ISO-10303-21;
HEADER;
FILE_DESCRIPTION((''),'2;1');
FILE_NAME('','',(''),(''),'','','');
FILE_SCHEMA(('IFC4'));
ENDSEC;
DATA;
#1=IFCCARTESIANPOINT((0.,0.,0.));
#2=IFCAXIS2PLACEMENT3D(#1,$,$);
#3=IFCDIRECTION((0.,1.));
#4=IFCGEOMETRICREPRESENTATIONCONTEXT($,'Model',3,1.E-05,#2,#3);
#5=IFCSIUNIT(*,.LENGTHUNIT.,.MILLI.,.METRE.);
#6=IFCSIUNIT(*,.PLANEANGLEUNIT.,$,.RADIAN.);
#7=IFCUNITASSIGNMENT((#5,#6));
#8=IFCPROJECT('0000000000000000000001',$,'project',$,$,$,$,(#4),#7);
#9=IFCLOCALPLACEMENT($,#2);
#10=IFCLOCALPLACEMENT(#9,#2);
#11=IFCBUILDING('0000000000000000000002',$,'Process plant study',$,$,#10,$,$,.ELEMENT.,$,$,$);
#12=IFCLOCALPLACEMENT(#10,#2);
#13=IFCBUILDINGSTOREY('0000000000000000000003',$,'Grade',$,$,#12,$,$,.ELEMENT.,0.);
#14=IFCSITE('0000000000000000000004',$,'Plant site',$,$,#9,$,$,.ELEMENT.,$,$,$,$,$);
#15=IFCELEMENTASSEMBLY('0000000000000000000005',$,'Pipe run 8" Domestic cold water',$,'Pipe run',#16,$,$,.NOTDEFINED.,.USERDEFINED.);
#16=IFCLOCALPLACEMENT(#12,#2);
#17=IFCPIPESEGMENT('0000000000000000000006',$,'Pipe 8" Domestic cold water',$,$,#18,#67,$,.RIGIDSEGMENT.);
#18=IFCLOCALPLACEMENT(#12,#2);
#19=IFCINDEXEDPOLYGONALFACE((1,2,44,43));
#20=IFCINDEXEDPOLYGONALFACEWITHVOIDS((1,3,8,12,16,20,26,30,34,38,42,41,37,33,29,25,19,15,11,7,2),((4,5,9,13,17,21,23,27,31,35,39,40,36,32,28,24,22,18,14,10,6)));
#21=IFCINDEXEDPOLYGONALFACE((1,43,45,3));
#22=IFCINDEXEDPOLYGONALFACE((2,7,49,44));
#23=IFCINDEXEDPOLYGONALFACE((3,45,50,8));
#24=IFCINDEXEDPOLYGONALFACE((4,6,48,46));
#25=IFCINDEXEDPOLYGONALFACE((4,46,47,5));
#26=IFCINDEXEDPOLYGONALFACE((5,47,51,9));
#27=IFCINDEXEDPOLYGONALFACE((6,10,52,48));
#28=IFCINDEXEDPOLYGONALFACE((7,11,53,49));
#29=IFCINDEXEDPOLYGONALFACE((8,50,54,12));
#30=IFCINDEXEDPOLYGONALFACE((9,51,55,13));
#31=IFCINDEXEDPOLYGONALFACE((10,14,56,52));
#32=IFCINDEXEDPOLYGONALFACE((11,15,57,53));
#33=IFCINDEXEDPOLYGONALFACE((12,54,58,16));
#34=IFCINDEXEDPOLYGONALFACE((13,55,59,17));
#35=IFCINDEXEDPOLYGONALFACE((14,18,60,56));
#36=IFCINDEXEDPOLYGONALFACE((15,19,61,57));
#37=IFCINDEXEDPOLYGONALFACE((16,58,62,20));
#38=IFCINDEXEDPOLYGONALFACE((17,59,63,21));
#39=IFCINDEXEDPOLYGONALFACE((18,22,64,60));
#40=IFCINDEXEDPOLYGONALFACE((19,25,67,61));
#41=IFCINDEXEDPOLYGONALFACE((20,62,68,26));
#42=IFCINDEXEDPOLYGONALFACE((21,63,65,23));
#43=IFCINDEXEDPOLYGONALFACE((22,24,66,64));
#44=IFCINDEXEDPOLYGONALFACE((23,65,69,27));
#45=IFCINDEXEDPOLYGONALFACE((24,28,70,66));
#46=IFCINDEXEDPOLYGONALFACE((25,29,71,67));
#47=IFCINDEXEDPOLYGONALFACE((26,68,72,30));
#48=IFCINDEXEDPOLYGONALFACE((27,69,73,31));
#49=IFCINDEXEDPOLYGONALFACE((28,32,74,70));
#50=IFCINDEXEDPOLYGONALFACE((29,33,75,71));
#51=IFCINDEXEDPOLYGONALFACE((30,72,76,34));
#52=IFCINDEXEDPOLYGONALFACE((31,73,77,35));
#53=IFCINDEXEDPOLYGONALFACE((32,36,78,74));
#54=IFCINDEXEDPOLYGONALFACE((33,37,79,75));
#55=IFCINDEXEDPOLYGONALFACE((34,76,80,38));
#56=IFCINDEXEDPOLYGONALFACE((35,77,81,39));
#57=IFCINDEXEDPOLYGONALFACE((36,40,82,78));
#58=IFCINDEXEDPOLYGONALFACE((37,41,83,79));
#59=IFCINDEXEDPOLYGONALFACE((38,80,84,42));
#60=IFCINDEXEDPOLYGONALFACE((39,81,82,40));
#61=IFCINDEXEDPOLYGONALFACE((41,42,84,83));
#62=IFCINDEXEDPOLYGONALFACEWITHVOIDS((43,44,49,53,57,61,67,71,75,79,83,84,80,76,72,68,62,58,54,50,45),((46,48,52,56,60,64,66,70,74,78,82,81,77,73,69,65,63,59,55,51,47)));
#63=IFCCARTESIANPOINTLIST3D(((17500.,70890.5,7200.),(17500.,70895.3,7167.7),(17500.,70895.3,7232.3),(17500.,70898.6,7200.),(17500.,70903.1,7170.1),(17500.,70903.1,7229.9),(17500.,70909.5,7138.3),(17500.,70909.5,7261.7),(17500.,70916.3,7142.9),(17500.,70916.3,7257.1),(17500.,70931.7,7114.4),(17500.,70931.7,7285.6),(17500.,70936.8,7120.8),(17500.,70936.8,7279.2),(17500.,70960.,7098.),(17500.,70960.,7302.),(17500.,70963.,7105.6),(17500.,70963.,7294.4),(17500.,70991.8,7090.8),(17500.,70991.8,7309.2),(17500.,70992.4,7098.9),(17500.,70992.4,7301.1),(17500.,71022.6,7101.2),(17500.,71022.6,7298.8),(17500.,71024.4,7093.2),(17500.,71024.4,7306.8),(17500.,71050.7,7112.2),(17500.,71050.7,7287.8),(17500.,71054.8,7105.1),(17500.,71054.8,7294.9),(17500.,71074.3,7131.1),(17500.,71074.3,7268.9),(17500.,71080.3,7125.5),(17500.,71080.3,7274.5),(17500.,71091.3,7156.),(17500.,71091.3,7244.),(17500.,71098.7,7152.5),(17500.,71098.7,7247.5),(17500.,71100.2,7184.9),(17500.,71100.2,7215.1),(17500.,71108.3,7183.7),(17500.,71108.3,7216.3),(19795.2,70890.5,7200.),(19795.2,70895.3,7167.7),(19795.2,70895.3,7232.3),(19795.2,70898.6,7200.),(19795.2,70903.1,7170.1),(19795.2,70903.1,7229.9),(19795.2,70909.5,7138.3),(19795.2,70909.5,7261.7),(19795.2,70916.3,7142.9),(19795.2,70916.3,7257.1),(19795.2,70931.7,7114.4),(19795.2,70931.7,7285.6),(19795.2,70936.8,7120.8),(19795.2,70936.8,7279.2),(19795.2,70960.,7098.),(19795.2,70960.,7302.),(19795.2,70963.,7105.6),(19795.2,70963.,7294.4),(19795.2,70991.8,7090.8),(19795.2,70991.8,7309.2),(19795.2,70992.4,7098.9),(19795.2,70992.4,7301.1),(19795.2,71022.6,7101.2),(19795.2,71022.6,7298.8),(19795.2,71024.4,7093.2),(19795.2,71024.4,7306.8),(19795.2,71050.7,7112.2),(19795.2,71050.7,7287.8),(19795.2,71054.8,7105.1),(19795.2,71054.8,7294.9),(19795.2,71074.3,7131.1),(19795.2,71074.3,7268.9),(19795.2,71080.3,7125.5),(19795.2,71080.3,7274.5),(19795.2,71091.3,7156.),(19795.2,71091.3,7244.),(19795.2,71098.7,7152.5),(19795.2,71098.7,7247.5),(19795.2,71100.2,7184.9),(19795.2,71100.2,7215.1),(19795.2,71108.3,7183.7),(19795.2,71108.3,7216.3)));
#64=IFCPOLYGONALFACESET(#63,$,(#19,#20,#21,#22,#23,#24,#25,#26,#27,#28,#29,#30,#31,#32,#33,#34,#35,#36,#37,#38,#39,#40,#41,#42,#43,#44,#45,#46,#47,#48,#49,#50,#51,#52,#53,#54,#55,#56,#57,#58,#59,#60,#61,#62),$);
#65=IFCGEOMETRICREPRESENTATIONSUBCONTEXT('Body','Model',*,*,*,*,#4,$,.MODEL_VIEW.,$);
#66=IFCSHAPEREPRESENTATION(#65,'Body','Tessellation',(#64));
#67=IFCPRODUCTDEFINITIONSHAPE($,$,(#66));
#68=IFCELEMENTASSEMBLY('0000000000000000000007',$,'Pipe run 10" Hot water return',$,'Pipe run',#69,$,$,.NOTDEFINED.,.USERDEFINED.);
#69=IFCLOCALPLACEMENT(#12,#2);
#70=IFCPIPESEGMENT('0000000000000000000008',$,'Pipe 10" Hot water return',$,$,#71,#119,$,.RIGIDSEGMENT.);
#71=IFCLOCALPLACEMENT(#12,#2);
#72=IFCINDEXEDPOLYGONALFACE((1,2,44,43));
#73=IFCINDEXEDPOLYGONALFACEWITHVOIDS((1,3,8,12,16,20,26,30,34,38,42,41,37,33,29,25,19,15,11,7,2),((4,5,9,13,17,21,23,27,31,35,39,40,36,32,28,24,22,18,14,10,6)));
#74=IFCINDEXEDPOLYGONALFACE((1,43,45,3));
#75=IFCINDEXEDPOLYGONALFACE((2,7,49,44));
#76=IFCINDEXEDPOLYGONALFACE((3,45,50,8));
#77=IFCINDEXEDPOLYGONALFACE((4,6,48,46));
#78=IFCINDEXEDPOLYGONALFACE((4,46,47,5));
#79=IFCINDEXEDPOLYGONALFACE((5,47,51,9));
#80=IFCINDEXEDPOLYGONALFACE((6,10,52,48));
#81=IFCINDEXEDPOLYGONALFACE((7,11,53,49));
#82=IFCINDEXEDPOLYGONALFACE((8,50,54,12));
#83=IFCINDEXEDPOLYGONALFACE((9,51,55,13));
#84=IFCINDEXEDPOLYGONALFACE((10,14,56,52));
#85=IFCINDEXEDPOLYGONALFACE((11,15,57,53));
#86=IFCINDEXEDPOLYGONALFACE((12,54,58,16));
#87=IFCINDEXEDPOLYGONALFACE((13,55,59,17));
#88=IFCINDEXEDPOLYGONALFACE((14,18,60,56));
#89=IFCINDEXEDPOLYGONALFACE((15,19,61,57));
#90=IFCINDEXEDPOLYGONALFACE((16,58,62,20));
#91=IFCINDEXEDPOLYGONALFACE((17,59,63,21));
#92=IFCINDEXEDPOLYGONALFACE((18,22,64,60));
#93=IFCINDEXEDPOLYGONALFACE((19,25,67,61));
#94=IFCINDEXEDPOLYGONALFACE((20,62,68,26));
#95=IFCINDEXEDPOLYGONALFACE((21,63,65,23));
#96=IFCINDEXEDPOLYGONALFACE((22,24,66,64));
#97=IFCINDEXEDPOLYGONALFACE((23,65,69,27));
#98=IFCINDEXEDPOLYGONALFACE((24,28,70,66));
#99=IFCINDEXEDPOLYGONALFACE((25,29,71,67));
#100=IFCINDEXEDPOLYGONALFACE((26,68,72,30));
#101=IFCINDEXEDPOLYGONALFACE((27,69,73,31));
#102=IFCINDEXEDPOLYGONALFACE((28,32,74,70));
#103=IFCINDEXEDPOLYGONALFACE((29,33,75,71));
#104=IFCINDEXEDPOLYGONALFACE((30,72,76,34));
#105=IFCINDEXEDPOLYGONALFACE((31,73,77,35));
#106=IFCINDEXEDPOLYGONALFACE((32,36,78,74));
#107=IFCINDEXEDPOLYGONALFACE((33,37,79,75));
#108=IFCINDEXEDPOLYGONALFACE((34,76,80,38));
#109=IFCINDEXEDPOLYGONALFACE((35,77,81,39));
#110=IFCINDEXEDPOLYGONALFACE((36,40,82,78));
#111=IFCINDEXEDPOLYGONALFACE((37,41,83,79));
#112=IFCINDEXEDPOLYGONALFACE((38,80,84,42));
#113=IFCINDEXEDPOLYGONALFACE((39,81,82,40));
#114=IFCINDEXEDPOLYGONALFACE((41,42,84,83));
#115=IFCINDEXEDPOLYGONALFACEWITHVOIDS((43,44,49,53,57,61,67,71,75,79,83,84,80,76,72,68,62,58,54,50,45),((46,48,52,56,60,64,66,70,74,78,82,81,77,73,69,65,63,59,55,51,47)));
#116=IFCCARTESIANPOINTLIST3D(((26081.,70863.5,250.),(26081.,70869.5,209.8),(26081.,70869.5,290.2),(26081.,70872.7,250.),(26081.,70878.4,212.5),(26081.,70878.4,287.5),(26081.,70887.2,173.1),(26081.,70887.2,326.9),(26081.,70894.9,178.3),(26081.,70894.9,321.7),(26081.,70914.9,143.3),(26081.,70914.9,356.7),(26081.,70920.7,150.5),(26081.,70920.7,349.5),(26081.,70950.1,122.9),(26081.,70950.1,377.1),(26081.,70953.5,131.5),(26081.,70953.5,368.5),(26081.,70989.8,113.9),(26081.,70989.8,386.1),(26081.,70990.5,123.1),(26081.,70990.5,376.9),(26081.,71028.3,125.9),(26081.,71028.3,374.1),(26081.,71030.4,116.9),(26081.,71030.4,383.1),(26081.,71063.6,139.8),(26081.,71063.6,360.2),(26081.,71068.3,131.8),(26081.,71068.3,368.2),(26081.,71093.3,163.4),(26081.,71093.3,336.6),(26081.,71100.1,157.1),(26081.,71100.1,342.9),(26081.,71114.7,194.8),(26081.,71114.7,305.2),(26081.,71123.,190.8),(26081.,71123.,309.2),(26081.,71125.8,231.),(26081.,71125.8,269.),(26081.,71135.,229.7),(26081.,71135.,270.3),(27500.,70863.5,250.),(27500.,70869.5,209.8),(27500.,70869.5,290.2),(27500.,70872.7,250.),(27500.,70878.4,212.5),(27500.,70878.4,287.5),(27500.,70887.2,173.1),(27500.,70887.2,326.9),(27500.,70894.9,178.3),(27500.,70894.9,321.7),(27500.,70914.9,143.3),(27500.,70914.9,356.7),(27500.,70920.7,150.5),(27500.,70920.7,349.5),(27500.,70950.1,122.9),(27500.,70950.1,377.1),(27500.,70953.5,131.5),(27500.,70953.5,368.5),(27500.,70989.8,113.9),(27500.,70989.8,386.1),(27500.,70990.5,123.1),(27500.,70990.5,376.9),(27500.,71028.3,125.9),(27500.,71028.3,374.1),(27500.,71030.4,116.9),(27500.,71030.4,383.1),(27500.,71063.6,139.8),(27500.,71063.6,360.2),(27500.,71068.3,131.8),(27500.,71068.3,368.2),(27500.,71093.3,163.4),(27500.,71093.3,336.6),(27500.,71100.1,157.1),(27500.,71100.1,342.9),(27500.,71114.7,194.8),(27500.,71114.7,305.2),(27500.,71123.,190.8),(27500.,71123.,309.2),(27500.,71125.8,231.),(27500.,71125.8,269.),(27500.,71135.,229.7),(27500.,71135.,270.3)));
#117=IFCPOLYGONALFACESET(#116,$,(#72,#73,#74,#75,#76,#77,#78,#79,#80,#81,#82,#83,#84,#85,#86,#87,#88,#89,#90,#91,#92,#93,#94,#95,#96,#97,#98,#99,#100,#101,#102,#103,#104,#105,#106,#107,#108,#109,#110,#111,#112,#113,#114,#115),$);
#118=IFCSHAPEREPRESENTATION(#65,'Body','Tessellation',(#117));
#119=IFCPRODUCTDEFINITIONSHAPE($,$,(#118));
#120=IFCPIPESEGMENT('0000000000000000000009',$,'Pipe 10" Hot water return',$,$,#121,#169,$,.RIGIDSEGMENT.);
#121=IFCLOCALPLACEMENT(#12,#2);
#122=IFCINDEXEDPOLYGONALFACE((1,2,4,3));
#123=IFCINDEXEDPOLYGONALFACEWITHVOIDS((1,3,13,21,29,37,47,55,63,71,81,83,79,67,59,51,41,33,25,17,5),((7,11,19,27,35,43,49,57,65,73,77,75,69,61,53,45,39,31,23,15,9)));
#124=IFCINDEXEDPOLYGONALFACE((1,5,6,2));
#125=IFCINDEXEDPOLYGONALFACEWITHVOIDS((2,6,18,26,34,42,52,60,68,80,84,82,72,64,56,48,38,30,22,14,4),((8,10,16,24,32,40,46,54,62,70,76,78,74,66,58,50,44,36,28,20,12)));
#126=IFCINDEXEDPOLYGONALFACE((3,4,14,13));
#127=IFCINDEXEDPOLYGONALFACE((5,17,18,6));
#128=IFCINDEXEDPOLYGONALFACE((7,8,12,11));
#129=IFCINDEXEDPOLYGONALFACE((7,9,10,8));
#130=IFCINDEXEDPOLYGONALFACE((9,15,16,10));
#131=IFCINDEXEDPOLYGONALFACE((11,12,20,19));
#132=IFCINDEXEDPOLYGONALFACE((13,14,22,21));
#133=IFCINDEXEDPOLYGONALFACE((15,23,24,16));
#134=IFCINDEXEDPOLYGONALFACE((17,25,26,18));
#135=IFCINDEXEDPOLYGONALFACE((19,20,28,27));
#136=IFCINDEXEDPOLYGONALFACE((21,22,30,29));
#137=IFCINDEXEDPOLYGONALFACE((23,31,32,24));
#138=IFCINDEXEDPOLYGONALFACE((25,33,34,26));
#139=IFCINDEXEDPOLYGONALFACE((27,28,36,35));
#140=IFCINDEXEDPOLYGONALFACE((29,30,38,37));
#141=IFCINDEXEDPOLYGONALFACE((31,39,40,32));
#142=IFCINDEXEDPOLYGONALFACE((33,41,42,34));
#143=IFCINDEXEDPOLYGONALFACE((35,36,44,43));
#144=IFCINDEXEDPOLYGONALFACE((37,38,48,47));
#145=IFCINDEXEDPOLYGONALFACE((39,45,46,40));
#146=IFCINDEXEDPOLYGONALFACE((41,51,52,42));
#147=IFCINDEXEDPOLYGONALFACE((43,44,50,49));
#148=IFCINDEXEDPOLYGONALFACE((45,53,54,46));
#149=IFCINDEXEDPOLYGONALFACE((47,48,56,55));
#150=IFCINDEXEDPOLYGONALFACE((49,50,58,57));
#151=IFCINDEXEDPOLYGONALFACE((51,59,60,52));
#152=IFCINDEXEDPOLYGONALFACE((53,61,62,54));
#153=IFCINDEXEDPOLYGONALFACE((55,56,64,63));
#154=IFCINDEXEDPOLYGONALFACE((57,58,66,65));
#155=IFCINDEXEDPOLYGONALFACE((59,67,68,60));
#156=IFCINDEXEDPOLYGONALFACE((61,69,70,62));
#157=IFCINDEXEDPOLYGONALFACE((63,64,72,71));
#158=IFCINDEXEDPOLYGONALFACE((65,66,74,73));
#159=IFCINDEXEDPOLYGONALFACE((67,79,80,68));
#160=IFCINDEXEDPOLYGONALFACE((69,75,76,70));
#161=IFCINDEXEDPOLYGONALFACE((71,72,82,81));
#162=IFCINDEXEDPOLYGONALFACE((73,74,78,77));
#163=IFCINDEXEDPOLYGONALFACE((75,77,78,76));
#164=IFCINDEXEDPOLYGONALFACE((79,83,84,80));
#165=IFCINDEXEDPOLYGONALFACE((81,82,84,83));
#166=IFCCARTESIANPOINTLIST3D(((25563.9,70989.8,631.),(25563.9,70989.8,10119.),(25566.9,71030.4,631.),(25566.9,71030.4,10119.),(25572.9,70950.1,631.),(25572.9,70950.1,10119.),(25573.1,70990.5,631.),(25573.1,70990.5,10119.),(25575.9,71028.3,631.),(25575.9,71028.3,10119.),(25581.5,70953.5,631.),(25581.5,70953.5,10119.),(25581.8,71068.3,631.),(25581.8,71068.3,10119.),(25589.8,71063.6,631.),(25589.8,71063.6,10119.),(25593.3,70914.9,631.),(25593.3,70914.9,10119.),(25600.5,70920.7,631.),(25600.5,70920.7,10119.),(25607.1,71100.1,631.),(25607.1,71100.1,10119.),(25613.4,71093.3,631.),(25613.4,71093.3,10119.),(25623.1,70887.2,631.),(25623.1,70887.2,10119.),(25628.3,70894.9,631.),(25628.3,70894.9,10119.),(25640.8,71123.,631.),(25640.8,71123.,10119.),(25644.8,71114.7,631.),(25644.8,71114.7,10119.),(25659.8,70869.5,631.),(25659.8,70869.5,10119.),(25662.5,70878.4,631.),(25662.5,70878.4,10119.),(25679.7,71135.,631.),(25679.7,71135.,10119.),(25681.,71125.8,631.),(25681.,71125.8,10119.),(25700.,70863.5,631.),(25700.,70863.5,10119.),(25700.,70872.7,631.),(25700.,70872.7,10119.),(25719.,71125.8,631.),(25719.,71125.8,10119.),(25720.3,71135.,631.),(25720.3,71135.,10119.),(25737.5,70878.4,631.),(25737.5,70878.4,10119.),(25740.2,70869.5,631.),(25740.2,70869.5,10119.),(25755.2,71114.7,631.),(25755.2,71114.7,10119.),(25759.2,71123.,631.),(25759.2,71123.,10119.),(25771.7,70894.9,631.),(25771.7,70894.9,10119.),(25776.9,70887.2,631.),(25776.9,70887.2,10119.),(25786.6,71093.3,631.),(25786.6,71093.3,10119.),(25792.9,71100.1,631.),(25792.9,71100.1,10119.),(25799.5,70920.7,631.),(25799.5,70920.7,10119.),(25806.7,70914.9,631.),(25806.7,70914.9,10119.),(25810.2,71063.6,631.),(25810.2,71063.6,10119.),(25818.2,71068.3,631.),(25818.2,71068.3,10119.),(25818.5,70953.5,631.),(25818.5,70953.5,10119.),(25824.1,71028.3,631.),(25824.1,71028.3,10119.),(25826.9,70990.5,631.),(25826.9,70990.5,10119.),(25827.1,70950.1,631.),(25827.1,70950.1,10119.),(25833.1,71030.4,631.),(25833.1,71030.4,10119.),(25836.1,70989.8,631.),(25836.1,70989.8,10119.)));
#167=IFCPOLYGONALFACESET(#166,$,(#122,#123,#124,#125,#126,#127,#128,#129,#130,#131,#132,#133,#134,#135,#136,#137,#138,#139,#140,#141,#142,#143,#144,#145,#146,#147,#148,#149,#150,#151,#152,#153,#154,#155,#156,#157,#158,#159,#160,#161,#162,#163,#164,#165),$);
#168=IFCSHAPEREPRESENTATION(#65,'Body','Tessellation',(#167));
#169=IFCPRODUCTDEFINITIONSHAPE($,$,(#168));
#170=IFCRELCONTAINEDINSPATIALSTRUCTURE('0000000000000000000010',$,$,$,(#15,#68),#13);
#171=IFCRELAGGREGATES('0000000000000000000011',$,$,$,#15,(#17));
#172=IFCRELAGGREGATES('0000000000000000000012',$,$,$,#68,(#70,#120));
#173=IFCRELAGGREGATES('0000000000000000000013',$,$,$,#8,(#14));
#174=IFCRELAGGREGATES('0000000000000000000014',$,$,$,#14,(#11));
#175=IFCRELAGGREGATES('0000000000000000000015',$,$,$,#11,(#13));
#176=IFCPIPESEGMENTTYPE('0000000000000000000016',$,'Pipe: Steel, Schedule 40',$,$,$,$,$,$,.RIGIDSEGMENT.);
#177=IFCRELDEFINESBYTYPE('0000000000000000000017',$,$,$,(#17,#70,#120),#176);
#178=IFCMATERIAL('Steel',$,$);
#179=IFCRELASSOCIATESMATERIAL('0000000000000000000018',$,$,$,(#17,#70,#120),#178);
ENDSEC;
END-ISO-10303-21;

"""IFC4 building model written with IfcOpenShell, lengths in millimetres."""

from ifc_helpers import new_model, si_unit, direction, frame, origin, origin_with_axes, origin_2d, place, context, subcontext, project, spatial, hollow_circle, extrude, material, type_object, element, aggregate, save


model = new_model("IFC4")

# Units and contexts
model_context = context("Model", 3, precision=1e-05, world=origin(), true_north=direction((0.0, 1.0)))
body_context = subcontext(model_context, "Body", "Model", "MODEL_VIEW")
ifc_project = project(units=[si_unit("LENGTHUNIT", "METRE", prefix="MILLI"), si_unit("PLANEANGLEUNIT", "RADIAN")], contexts=[model_context])

# Site, building, storey
site_placement = place(None, origin())
site = spatial("IfcSite", under=ifc_project, at=site_placement, Name="Plant site", CompositionType="ELEMENT")
building_placement = place(site_placement, origin())
building = spatial("IfcBuilding", under=site, at=building_placement, Name="Process plant study", CompositionType="ELEMENT")
storey_placement = place(building_placement, origin())
storey = spatial("IfcBuildingStorey", under=building, at=storey_placement, Name="Grade", CompositionType="ELEMENT", Elevation=0.0)

# Element assembly, pipe segment
assembly_1_placement = place(storey_placement, origin_with_axes())
assembly_1 = element("IfcElementAssembly", 1, at=assembly_1_placement, inside=storey, Name="Pipe run 8\" Domestic cold water", ObjectType="Pipe run", AssemblyPlace="NOTDEFINED", PredefinedType="USERDEFINED")
ifc_material = material(Name="Steel")
pipe_segment_type = type_object("IfcPipeSegmentType", Name="Pipe: Steel, Schedule 40", PredefinedType="RIGIDSEGMENT")
pipe_segment_1_placement = place(storey_placement, origin_with_axes())
pipe_segment_1 = element("IfcPipeSegment", 2, at=pipe_segment_1_placement, type_object=pipe_segment_type, material=ifc_material, Name="Pipe 8\" Domestic cold water", PredefinedType="RIGIDSEGMENT", context=body_context, shape_type="SweptSolid", body=[
    extrude(hollow_circle(Radius=109.5, WallThickness=8.2, at=origin_2d()), frame((19795.2, 71000.0, 7200.0), z_axis=(-1.0, 0.0, 0.0), x_axis=(0.0, -1.0, 0.0)), (0.0, 0.0, 1.0), 2295.2),
])

# Element assembly, pipe segments
assembly_2_placement = place(storey_placement, origin_with_axes())
assembly_2 = element("IfcElementAssembly", 3, at=assembly_2_placement, inside=storey, Name="Pipe run 10\" Hot water return", ObjectType="Pipe run", AssemblyPlace="NOTDEFINED", PredefinedType="USERDEFINED")
pipe_segment_2_placement = place(storey_placement, origin_with_axes())
pipe_segment_2 = element("IfcPipeSegment", 4, at=pipe_segment_2_placement, type_object=pipe_segment_type, material=ifc_material, Name="Pipe 10\" Hot water return", PredefinedType="RIGIDSEGMENT", context=body_context, shape_type="SweptSolid", body=[
    extrude(hollow_circle(Radius=136.5, WallThickness=9.3, at=origin_2d()), frame((27500.0, 71000.0, 250.0), z_axis=(-1.0, 0.0, 0.0), x_axis=(0.0, -1.0, 0.0)), (0.0, 0.0, 1.0), 1419.0),
])
pipe_segment_3_placement = place(storey_placement, origin_with_axes())
pipe_segment_3 = element("IfcPipeSegment", 5, at=pipe_segment_3_placement, type_object=pipe_segment_type, material=ifc_material, Name="Pipe 10\" Hot water return", PredefinedType="RIGIDSEGMENT", context=body_context, shape_type="SweptSolid", body=[
    extrude(hollow_circle(Radius=136.5, WallThickness=9.3, at=origin_2d()), frame((25700.0, 71000.0, 631.0), z_axis=(0.0, 0.0, 1.0), x_axis=(0.0, -1.0, 0.0)), (0.0, 0.0, 1.0), 9488.0),
])

aggregate(assembly_1, [pipe_segment_1])
aggregate(assembly_2, [pipe_segment_2, pipe_segment_3])

save(model, "model.ifc")
